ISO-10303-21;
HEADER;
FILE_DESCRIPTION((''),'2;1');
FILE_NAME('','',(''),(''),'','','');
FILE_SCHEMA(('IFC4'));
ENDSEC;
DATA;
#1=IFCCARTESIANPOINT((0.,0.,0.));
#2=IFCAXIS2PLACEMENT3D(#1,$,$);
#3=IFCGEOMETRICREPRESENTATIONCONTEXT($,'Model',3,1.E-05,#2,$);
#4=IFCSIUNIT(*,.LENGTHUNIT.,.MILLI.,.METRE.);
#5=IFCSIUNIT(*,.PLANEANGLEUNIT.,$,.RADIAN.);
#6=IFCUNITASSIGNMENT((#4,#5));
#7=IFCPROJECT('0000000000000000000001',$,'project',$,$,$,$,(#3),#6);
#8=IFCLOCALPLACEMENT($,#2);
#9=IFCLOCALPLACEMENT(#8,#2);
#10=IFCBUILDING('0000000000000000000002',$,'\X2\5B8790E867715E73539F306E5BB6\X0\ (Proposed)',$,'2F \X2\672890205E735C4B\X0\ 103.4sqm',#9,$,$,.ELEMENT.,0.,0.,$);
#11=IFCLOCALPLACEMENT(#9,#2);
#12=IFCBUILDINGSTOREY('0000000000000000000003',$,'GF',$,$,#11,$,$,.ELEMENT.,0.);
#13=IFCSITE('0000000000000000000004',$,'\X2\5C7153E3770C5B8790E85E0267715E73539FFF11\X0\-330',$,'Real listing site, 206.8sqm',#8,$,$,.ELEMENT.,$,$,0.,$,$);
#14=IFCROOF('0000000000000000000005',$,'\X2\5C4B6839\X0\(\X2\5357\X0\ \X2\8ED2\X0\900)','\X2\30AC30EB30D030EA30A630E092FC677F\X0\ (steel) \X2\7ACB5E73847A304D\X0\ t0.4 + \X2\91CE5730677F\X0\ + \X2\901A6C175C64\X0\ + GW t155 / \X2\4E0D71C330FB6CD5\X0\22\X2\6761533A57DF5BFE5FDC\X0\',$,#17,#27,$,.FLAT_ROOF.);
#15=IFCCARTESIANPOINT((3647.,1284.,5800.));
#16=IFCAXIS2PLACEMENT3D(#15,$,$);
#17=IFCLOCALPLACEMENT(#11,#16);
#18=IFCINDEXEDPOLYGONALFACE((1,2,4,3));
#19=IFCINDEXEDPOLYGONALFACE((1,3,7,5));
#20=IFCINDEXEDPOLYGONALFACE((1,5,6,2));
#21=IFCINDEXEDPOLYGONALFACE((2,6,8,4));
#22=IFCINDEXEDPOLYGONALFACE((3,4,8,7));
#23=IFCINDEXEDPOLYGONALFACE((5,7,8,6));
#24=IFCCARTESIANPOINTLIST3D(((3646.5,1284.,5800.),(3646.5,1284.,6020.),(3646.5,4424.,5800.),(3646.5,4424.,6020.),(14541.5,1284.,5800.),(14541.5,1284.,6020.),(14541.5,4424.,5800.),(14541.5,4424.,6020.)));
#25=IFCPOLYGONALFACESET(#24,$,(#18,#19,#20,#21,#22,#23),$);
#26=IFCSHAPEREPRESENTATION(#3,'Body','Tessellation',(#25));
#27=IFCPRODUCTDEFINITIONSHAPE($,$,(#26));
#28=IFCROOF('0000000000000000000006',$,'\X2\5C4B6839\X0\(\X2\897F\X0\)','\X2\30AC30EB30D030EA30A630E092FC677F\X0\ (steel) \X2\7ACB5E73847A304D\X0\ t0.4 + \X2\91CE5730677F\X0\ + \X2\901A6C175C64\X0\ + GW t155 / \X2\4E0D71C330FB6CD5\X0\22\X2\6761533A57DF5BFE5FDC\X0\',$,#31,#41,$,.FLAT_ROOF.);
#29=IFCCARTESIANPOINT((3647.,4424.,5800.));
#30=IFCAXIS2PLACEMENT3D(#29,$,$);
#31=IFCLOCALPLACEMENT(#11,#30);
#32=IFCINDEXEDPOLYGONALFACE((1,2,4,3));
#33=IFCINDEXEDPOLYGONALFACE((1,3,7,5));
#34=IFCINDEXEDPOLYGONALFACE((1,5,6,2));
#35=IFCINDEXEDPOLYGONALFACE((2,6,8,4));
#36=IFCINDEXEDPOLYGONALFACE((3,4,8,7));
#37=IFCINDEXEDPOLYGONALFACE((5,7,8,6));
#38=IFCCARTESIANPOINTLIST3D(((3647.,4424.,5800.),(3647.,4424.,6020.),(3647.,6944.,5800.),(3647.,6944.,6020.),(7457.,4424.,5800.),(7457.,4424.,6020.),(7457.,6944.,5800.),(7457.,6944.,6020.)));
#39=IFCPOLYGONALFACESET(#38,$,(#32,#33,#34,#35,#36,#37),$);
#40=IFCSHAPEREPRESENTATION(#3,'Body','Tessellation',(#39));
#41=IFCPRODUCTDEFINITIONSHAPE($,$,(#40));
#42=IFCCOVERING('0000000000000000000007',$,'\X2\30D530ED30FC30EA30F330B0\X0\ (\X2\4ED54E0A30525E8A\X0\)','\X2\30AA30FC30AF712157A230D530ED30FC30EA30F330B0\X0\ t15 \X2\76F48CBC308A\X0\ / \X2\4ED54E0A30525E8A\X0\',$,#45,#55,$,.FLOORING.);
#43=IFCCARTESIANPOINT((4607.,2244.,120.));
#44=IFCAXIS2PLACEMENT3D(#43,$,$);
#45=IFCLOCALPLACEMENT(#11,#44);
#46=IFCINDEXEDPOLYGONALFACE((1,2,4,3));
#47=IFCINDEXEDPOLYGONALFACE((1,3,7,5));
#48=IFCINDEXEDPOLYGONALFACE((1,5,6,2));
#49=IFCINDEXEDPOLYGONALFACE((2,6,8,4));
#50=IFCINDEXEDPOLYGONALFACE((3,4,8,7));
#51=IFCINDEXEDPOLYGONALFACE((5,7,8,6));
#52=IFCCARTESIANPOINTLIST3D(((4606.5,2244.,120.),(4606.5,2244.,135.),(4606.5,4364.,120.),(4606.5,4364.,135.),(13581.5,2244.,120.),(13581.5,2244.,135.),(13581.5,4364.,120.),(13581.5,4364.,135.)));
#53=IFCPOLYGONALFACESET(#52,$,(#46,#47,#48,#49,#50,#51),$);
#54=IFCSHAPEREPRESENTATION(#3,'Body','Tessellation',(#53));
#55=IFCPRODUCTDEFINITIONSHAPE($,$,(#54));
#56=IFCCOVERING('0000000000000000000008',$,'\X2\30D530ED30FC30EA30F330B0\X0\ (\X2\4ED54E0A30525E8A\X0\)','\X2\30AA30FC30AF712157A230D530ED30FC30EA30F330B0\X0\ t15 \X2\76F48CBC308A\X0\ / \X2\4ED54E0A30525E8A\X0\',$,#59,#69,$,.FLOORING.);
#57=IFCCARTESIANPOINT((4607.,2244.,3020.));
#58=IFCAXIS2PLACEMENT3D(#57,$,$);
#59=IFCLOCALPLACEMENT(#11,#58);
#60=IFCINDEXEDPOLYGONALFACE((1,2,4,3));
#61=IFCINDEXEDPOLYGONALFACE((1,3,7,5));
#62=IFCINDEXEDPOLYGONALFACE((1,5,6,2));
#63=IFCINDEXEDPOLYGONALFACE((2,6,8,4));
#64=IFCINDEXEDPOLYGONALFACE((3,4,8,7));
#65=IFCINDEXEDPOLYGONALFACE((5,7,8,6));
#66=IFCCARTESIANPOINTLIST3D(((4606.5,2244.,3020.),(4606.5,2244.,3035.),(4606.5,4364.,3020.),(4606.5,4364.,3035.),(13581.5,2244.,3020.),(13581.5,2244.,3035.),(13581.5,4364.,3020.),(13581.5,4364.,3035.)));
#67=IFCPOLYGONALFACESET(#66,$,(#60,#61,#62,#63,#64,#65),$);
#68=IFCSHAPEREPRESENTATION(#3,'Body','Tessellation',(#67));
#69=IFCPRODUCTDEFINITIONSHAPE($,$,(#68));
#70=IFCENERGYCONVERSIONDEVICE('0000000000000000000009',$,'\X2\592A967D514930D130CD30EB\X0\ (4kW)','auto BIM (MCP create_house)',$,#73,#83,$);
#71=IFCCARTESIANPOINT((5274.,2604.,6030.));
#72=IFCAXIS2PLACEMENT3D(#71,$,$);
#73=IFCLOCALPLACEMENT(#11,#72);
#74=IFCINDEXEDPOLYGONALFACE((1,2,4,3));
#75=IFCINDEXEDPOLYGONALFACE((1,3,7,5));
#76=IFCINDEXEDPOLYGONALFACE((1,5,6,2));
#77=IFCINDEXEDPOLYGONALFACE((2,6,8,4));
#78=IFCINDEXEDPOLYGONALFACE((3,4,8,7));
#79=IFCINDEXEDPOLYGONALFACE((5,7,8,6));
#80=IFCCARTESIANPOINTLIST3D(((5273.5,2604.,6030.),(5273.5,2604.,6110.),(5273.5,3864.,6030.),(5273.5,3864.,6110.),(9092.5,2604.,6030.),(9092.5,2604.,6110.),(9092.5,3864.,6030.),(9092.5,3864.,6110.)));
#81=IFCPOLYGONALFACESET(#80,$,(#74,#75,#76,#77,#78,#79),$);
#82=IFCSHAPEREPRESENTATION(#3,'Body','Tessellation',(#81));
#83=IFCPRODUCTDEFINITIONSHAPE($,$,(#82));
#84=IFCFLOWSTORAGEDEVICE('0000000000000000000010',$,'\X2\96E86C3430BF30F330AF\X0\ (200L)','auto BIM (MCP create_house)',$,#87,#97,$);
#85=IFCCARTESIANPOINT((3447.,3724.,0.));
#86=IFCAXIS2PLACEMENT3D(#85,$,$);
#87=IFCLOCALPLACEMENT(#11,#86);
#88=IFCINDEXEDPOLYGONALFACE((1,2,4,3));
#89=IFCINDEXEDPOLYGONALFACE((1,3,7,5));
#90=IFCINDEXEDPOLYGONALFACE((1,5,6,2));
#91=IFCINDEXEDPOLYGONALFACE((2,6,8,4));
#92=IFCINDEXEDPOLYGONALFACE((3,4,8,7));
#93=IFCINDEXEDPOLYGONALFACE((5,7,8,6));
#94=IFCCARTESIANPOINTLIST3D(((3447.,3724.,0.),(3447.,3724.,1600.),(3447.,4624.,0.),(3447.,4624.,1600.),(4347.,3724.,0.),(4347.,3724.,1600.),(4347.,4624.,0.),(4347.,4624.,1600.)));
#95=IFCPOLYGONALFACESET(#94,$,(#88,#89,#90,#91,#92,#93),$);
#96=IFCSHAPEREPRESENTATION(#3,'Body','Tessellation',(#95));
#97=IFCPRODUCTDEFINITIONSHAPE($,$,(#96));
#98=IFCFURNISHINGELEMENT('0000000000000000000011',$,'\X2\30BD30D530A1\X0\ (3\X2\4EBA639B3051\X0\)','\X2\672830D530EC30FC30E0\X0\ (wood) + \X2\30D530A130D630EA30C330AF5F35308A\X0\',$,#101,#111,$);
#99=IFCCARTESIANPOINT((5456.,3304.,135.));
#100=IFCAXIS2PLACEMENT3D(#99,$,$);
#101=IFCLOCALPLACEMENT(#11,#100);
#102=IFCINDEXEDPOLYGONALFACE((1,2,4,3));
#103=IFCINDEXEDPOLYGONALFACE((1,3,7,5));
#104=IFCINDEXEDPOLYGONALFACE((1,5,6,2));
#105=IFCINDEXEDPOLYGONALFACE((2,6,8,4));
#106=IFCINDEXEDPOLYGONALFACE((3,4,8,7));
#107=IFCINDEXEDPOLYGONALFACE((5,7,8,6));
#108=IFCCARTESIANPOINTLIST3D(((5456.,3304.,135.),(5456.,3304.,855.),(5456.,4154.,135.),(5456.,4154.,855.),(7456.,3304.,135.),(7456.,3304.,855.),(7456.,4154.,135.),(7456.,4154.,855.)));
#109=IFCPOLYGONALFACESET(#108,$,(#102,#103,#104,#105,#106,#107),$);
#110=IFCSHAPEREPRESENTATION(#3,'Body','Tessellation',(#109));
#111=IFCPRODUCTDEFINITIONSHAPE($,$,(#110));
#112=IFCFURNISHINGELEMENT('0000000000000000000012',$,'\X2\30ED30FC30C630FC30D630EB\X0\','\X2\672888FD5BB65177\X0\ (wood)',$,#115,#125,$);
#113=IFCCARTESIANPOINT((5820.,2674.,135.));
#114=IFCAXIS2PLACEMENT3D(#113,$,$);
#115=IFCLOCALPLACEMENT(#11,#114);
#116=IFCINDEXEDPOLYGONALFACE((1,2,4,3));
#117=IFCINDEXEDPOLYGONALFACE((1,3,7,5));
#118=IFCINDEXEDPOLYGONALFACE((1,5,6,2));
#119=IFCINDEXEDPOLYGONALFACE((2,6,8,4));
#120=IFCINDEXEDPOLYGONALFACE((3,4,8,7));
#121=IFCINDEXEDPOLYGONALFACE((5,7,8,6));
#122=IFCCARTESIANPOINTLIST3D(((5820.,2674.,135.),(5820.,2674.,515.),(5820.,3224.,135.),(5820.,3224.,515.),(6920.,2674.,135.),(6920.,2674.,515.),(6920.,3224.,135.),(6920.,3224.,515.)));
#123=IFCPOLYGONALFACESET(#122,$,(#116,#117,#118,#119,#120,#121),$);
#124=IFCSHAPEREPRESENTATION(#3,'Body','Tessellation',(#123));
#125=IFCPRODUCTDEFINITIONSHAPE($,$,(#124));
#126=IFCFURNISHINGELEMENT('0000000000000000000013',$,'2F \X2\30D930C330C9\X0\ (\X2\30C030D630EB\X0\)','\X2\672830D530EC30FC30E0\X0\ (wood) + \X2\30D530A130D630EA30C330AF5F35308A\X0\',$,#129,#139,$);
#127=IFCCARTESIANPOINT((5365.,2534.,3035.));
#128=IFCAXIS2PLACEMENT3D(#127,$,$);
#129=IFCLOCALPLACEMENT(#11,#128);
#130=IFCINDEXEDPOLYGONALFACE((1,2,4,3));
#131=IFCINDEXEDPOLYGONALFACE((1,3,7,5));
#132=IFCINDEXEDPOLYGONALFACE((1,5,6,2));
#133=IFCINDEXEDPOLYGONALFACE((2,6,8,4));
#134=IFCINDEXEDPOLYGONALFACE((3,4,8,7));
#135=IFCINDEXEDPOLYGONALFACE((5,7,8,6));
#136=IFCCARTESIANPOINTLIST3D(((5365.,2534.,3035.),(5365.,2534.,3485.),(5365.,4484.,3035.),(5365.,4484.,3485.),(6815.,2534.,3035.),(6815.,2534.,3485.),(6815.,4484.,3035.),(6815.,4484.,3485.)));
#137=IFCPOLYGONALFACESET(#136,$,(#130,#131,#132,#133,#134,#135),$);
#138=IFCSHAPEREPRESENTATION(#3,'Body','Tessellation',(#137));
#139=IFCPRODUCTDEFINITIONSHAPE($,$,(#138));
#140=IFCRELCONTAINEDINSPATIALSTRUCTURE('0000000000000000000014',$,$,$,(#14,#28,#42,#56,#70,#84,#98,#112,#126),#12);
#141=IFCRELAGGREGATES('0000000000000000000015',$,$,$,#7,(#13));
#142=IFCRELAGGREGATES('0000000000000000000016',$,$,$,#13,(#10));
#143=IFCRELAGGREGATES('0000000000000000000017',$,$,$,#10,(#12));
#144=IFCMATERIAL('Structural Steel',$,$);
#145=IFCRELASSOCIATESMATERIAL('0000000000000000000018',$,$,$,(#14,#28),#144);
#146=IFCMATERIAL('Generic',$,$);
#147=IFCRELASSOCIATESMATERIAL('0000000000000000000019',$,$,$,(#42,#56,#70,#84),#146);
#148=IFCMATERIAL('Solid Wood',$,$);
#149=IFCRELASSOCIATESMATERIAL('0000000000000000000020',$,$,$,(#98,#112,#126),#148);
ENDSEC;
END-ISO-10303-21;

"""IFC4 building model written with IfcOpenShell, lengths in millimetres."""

from ifc_helpers import new_model, si_unit, frame, frame_2d, origin, place, context, project, spatial, rectangle, extrude, material, element, save


model = new_model("IFC4")

# Units and contexts
model_context = context("Model", 3, precision=1e-05, world=origin())
ifc_project = project(units=[si_unit("LENGTHUNIT", "METRE", prefix="MILLI"), si_unit("PLANEANGLEUNIT", "RADIAN")], contexts=[model_context])

# Site, building, storey
site_placement = place(None, origin())
site = spatial("IfcSite", under=ifc_project, at=site_placement, Name="山口県宇部市東平原１-330", ObjectType="Real listing site, 206.8sqm", CompositionType="ELEMENT", RefElevation=0.0)
building_placement = place(site_placement, origin())
building = spatial("IfcBuilding", under=site, at=building_placement, Name="宇部東平原の家 (Proposed)", ObjectType="2F 木造平屋 103.4sqm", CompositionType="ELEMENT", ElevationOfRefHeight=0.0, ElevationOfTerrain=0.0)
storey_placement = place(building_placement, origin())
storey = spatial("IfcBuildingStorey", under=building, at=storey_placement, Name="GF", CompositionType="ELEMENT", Elevation=0.0)

# Shared definitions
ifc_material_1 = material(Name="Solid Wood")

# Roofs
ifc_material_2 = material(Name="Structural Steel")
roof_1_placement = place(storey_placement, frame((3647.0, 1284.0, 5800.0)))
element("IfcRoof", 1, at=roof_1_placement, inside=storey, material=ifc_material_2, Name="屋根(南 軒900)", Description="ガルバリウム鋼板 (steel) 立平葺き t0.4 + 野地板 + 通気層 + GW t155 / 不燃・法22条区域対応", PredefinedType="FLAT_ROOF", context=model_context, shape_type="SweptSolid", body=[
    extrude(rectangle(XDim=10895.0, YDim=3140.0, at=frame_2d((5447.0, 1570.0))), frame((3647.0, 1284.0, 5800.0)), (0.0, 0.0, 1.0), 220.0),
])
roof_2_placement = place(storey_placement, frame((3647.0, 4424.0, 5800.0)))
element("IfcRoof", 2, at=roof_2_placement, inside=storey, material=ifc_material_2, Name="屋根(西)", Description="ガルバリウム鋼板 (steel) 立平葺き t0.4 + 野地板 + 通気層 + GW t155 / 不燃・法22条区域対応", PredefinedType="FLAT_ROOF", context=model_context, shape_type="SweptSolid", body=[
    extrude(rectangle(XDim=3810.0, YDim=2520.0, at=frame_2d((1905.0, 1260.0))), frame((3647.0, 4424.0, 5800.0)), (0.0, 0.0, 1.0), 220.0),
])

# Coverings
ifc_material_3 = material(Name="Generic")
covering_1_placement = place(storey_placement, frame((4607.0, 2244.0, 120.0)))
element("IfcCovering", 3, at=covering_1_placement, inside=storey, material=ifc_material_3, Name="フローリング (仕上げ床)", Description="オーク無垢フローリング t15 直貼り / 仕上げ床", PredefinedType="FLOORING", context=model_context, shape_type="SweptSolid", body=[
    extrude(rectangle(XDim=8975.0, YDim=2120.0, at=frame_2d((4487.0, 1060.0))), frame((4607.0, 2244.0, 120.0)), (0.0, 0.0, 1.0), 15.0),
])
covering_2_placement = place(storey_placement, frame((4607.0, 2244.0, 3020.0)))
element("IfcCovering", 4, at=covering_2_placement, inside=storey, material=ifc_material_3, Name="フローリング (仕上げ床)", Description="オーク無垢フローリング t15 直貼り / 仕上げ床", PredefinedType="FLOORING", context=model_context, shape_type="SweptSolid", body=[
    extrude(rectangle(XDim=8975.0, YDim=2120.0, at=frame_2d((4487.0, 1060.0))), frame((4607.0, 2244.0, 3020.0)), (0.0, 0.0, 1.0), 15.0),
])

# Energy conversion device
energy_conversion_device_placement = place(storey_placement, frame((5274.0, 2604.0, 6030.0)))
element("IfcEnergyConversionDevice", 5, at=energy_conversion_device_placement, inside=storey, material=ifc_material_3, Name="太陽光パネル (4kW)", Description="auto BIM (MCP create_house)", context=model_context, shape_type="SweptSolid", body=[
    extrude(rectangle(XDim=3819.0, YDim=1260.0, at=frame_2d((1909.0, 630.0))), frame((5274.0, 2604.0, 6030.0)), (0.0, 0.0, 1.0), 80.0),
])

# Flow storage device
flow_storage_device_placement = place(storey_placement, frame((3447.0, 3724.0, 0.0)))
element("IfcFlowStorageDevice", 6, at=flow_storage_device_placement, inside=storey, material=ifc_material_3, Name="雨水タンク (200L)", Description="auto BIM (MCP create_house)", context=model_context, shape_type="SweptSolid", body=[
    extrude(rectangle(XDim=900.0, YDim=900.0, at=frame_2d((450.0, 450.0))), frame((3447.0, 3724.0, 0.0)), (0.0, 0.0, 1.0), 1600.0),
])

# Furnishing elements
furnishing_1_placement = place(storey_placement, frame((5456.0, 3304.0, 135.0)))
element("IfcFurnishingElement", 7, at=furnishing_1_placement, inside=storey, material=ifc_material_1, Name="ソファ (3人掛け)", Description="木フレーム (wood) + ファブリック張り", context=model_context, shape_type="SweptSolid", body=[
    extrude(rectangle(XDim=2000.0, YDim=850.0, at=frame_2d((1000.0, 425.0))), frame((5456.0, 3304.0, 135.0)), (0.0, 0.0, 1.0), 720.0),
])
furnishing_2_placement = place(storey_placement, frame((5820.0, 2674.0, 135.0)))
element("IfcFurnishingElement", 8, at=furnishing_2_placement, inside=storey, material=ifc_material_1, Name="ローテーブル", Description="木製家具 (wood)", context=model_context, shape_type="SweptSolid", body=[
    extrude(rectangle(XDim=1100.0, YDim=550.0, at=frame_2d((550.0, 275.0))), frame((5820.0, 2674.0, 135.0)), (0.0, 0.0, 1.0), 380.0),
])
furnishing_3_placement = place(storey_placement, frame((5365.0, 2534.0, 3035.0)))
element("IfcFurnishingElement", 9, at=furnishing_3_placement, inside=storey, material=ifc_material_1, Name="2F ベッド (ダブル)", Description="木フレーム (wood) + ファブリック張り", context=model_context, shape_type="SweptSolid", body=[
    extrude(rectangle(XDim=1450.0, YDim=1950.0, at=frame_2d((725.0, 975.0))), frame((5365.0, 2534.0, 3035.0)), (0.0, 0.0, 1.0), 450.0),
])

save(model, "model.ifc")
